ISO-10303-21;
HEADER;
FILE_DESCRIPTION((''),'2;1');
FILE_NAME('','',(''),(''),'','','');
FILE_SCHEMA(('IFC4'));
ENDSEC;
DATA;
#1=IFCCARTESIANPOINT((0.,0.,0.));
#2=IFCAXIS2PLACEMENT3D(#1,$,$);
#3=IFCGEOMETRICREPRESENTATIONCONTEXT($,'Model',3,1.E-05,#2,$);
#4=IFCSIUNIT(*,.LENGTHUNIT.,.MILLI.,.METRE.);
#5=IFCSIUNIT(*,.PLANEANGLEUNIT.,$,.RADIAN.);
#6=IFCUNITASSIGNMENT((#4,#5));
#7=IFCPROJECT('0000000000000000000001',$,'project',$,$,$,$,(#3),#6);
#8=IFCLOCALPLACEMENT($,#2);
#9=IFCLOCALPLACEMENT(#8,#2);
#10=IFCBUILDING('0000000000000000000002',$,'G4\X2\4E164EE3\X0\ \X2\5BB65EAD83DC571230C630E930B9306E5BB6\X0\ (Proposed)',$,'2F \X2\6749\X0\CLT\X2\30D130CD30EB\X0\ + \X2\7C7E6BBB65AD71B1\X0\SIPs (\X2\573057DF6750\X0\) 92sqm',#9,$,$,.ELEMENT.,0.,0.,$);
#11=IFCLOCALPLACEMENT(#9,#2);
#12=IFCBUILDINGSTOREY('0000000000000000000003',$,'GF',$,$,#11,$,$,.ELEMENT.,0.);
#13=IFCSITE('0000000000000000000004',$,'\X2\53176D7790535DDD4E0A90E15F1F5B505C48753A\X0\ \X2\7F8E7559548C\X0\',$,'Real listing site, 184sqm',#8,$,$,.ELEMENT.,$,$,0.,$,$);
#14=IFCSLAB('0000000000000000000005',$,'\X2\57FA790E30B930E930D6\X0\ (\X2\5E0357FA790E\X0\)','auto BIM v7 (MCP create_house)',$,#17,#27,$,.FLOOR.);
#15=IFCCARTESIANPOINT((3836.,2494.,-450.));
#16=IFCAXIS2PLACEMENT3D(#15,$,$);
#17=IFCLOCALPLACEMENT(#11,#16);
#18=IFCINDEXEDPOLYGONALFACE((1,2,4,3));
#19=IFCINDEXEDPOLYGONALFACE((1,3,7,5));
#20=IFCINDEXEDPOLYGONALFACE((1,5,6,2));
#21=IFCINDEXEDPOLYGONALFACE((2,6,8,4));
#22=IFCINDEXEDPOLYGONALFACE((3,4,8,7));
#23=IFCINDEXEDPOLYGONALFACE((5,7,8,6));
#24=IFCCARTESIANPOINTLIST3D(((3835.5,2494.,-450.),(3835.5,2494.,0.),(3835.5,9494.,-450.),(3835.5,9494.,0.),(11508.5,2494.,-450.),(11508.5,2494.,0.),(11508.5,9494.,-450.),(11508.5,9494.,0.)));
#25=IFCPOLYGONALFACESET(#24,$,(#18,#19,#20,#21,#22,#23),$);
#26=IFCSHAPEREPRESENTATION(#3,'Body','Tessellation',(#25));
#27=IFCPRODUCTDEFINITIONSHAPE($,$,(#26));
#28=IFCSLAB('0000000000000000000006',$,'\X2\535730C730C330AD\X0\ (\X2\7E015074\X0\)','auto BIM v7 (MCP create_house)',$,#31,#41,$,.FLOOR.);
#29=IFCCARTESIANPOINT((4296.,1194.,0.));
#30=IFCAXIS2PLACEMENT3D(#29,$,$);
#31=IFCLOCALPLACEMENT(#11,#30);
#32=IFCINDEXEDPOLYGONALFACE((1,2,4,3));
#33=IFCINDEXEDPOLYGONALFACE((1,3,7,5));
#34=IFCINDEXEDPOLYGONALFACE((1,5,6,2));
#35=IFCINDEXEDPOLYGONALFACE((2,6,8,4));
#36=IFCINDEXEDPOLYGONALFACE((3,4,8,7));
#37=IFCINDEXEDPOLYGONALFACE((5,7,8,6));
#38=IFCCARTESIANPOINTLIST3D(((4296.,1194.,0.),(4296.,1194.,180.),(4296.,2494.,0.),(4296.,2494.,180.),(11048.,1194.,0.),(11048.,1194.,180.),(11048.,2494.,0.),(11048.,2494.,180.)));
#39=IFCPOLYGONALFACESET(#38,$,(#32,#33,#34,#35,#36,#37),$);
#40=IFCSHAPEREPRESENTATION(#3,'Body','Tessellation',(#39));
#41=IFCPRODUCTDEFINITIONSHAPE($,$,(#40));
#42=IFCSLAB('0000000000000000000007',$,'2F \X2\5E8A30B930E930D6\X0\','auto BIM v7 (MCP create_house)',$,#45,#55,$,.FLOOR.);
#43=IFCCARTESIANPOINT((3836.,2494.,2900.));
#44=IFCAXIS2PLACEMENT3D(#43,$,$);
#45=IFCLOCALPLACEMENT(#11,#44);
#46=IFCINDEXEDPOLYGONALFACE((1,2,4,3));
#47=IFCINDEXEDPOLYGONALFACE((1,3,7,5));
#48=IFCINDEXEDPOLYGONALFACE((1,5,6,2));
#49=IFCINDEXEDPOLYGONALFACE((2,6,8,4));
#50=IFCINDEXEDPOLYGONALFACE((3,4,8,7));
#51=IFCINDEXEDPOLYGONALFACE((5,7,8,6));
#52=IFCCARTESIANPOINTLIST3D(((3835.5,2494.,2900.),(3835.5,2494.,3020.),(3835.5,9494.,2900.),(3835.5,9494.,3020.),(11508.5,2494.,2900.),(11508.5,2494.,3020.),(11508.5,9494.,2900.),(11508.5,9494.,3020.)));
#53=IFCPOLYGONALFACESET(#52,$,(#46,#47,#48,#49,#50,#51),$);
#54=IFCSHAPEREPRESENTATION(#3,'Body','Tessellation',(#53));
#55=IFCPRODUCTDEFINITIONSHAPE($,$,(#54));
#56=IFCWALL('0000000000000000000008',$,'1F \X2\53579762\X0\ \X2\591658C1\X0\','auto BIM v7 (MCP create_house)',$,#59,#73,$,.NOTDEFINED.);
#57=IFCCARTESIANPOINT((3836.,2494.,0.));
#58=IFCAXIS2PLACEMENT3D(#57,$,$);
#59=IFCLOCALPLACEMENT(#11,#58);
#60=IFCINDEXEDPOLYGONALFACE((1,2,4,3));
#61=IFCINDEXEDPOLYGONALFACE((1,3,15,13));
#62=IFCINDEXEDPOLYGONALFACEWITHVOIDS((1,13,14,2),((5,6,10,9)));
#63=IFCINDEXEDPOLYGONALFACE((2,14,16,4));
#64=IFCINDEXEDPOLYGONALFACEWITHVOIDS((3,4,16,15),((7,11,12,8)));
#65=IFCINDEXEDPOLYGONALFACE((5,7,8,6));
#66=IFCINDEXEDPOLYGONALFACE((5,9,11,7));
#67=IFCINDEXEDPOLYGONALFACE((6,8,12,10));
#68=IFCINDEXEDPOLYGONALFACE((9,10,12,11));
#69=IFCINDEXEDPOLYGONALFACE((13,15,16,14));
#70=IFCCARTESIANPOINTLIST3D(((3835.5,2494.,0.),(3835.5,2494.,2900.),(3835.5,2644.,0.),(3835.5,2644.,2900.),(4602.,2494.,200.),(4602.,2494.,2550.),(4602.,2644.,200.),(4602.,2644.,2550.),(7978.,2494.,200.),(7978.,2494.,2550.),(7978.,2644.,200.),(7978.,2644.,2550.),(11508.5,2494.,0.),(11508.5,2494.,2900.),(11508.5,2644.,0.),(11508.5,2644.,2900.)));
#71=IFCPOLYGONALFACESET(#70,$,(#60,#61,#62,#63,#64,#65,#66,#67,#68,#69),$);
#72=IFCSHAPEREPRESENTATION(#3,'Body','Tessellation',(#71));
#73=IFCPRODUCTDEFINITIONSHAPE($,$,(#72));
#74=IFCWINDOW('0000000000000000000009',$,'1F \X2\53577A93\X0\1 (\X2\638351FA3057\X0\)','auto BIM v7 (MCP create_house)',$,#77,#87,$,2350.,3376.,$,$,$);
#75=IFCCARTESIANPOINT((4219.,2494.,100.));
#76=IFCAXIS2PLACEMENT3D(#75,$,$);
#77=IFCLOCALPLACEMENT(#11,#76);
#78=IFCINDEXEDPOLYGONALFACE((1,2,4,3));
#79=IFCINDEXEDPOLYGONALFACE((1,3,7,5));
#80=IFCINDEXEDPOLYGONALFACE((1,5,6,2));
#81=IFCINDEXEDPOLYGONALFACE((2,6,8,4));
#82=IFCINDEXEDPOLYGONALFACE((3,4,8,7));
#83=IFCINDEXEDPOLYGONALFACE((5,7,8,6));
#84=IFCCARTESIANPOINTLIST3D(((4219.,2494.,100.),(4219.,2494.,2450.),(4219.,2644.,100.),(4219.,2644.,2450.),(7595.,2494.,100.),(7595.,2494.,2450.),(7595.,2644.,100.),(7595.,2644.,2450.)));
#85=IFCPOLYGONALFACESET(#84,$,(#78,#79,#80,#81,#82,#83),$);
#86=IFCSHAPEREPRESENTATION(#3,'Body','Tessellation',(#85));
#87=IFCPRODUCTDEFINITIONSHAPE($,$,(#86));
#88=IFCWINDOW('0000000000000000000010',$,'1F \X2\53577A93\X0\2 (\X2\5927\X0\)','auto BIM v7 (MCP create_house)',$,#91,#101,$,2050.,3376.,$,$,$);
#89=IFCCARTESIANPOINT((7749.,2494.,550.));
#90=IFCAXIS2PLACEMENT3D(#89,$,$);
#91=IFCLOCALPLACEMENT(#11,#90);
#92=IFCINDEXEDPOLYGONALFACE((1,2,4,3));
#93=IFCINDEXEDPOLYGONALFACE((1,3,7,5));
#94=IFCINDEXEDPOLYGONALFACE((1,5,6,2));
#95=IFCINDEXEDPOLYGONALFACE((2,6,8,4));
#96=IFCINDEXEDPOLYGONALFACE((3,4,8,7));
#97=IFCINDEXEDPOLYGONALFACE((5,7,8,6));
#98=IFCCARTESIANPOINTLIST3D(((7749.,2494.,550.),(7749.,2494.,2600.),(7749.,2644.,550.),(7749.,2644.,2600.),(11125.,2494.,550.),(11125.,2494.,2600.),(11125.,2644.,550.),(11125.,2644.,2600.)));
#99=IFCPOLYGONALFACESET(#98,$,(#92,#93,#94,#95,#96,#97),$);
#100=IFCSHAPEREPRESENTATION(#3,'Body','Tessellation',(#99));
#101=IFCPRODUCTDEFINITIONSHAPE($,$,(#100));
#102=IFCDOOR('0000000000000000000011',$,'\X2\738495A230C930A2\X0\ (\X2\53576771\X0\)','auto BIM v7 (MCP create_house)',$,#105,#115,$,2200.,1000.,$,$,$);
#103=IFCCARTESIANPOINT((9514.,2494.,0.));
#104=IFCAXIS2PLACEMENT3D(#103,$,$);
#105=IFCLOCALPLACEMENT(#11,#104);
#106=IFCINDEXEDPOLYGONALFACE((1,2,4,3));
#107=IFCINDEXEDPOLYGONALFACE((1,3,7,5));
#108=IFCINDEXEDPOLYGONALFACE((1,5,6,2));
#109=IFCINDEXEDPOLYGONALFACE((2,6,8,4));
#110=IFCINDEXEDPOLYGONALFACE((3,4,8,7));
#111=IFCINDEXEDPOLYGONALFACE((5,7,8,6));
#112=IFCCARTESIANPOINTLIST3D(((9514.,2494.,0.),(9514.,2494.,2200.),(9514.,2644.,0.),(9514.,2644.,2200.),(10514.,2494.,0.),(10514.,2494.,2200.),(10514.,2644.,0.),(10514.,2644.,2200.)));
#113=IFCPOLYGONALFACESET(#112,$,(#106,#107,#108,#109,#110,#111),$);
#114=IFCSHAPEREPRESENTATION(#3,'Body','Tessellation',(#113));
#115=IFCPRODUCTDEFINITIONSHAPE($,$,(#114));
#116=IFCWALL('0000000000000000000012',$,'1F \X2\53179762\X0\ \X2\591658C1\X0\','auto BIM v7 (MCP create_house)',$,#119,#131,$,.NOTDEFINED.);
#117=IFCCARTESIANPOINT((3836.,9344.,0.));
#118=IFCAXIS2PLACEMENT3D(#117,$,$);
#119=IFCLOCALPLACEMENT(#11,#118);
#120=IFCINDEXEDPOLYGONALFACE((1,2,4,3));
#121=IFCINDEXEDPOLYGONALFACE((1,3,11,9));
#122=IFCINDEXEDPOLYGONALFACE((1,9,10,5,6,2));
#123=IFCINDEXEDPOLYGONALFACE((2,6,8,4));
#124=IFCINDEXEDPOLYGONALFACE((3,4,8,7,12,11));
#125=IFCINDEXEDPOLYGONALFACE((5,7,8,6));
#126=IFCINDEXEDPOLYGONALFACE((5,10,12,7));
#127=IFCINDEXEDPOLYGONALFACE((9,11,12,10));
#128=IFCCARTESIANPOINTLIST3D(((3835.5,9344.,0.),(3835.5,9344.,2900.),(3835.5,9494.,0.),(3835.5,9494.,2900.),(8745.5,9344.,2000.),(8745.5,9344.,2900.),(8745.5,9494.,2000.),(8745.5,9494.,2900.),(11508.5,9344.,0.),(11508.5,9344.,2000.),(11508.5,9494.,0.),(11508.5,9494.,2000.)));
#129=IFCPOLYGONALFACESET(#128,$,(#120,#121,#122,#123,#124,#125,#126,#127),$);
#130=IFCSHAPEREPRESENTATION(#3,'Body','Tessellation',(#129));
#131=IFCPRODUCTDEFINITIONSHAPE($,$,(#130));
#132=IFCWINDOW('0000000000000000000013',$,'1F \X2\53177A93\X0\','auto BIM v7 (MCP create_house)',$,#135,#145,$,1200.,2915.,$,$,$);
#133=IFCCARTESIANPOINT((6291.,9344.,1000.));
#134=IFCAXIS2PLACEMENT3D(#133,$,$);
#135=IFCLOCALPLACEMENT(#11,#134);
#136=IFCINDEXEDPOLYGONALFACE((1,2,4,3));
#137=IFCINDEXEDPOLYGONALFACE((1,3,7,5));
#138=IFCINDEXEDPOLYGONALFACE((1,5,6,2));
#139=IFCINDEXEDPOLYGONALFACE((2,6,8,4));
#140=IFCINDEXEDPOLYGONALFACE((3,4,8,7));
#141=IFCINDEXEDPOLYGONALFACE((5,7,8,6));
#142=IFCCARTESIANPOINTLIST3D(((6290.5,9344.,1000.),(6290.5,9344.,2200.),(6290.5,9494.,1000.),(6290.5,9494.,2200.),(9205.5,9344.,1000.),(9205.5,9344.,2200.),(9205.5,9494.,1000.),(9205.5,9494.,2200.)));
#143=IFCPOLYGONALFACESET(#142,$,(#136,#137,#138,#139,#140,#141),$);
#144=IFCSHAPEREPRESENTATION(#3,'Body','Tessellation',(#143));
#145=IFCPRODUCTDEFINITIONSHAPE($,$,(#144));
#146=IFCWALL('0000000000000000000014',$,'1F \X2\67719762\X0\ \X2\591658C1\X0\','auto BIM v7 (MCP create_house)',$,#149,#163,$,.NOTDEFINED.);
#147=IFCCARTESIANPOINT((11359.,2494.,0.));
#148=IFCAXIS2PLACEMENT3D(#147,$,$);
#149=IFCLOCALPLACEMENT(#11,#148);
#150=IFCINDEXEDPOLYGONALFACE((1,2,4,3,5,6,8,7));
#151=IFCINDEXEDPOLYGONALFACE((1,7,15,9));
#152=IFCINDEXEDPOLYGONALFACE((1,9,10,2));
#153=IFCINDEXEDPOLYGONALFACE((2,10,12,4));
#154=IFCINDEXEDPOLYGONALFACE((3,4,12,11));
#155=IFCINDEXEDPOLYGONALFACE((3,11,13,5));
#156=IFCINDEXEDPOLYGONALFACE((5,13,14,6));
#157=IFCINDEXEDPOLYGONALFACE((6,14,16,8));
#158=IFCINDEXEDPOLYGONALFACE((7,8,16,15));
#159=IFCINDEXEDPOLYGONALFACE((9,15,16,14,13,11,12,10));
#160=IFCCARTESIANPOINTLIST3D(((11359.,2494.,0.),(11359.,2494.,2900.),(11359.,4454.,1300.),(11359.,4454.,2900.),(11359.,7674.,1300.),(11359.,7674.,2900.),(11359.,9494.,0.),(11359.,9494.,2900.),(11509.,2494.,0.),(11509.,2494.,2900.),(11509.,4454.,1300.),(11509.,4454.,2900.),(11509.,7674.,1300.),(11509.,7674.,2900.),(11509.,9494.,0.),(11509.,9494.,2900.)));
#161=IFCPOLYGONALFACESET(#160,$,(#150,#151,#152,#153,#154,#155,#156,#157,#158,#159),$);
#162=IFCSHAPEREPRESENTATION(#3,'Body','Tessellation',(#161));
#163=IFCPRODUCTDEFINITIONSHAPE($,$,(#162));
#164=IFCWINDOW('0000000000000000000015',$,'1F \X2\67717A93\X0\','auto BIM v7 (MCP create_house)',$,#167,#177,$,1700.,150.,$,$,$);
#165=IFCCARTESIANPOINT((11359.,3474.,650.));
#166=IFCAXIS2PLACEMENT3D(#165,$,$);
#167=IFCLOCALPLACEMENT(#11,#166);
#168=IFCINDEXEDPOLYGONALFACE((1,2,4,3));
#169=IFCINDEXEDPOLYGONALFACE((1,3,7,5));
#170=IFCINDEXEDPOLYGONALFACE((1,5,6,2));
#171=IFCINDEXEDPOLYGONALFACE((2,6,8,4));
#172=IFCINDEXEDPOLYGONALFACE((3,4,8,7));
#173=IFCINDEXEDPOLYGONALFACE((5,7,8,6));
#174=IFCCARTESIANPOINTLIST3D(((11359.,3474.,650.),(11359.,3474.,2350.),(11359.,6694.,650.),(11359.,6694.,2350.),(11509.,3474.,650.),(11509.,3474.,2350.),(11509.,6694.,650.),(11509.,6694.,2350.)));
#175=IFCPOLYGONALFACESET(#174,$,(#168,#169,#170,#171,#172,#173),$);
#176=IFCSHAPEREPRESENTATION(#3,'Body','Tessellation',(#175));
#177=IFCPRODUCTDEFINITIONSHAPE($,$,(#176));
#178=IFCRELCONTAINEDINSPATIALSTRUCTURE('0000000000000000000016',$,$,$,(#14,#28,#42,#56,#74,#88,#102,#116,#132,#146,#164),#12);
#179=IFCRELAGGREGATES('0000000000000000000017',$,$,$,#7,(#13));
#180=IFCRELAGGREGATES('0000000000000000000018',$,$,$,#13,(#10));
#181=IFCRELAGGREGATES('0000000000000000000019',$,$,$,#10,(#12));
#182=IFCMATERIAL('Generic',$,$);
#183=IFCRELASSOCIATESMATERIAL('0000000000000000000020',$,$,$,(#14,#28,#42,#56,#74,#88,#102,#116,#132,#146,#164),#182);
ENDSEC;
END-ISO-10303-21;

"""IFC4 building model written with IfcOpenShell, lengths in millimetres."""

from ifc_helpers import new_model, si_unit, frame, frame_2d, origin, place, context, project, spatial, rectangle, extrude, material, element, fill, save


model = new_model("IFC4")

# Units and contexts
model_context = context("Model", 3, precision=1e-05, world=origin())
ifc_project = project(units=[si_unit("LENGTHUNIT", "METRE", prefix="MILLI"), si_unit("PLANEANGLEUNIT", "RADIAN")], contexts=[model_context])

# Site, building, storey
site_placement = place(None, origin())
site = spatial("IfcSite", under=ifc_project, at=site_placement, Name="北海道川上郡弟子屈町 美留和", ObjectType="Real listing site, 184sqm", CompositionType="ELEMENT", RefElevation=0.0)
building_placement = place(site_placement, origin())
building = spatial("IfcBuilding", under=site, at=building_placement, Name="G4世代 家庭菜園テラスの家 (Proposed)", ObjectType="2F 杉CLTパネル + 籾殻断熱SIPs (地域材) 92sqm", CompositionType="ELEMENT", ElevationOfRefHeight=0.0, ElevationOfTerrain=0.0)
storey_placement = place(building_placement, origin())
storey = spatial("IfcBuildingStorey", under=building, at=storey_placement, Name="GF", CompositionType="ELEMENT", Elevation=0.0)

# Slabs
ifc_material = material(Name="Generic")
slab_1_placement = place(storey_placement, frame((3836.0, 2494.0, -450.0)))
element("IfcSlab", 1, at=slab_1_placement, inside=storey, material=ifc_material, Name="基礎スラブ (布基礎)", Description="auto BIM v7 (MCP create_house)", PredefinedType="FLOOR", context=model_context, shape_type="SweptSolid", body=[
    extrude(rectangle(XDim=7673.0, YDim=7000.0, at=frame_2d((3836.0, 3500.0))), frame((3836.0, 2494.0, -450.0)), (0.0, 0.0, 1.0), 450.0),
])
slab_2_placement = place(storey_placement, frame((4296.0, 1194.0, 0.0)))
element("IfcSlab", 2, at=slab_2_placement, inside=storey, material=ifc_material, Name="南デッキ (縁側)", Description="auto BIM v7 (MCP create_house)", PredefinedType="FLOOR", context=model_context, shape_type="SweptSolid", body=[
    extrude(rectangle(XDim=6752.0, YDim=1300.0, at=frame_2d((3376.0, 650.0))), frame((4296.0, 1194.0, 0.0)), (0.0, 0.0, 1.0), 180.0),
])
slab_3_placement = place(storey_placement, frame((3836.0, 2494.0, 2900.0)))
element("IfcSlab", 3, at=slab_3_placement, inside=storey, material=ifc_material, Name="2F 床スラブ", Description="auto BIM v7 (MCP create_house)", PredefinedType="FLOOR", context=model_context, shape_type="SweptSolid", body=[
    extrude(rectangle(XDim=7673.0, YDim=7000.0, at=frame_2d((3836.0, 3500.0))), frame((3836.0, 2494.0, 2900.0)), (0.0, 0.0, 1.0), 120.0),
])

# Wall, openings, windows, door
wall_1_placement = place(storey_placement, frame((3836.0, 2494.0, 0.0)))
wall_1 = element("IfcWall", 4, at=wall_1_placement, inside=storey, material=ifc_material, Name="1F 南面 外壁", Description="auto BIM v7 (MCP create_house)", PredefinedType="NOTDEFINED", context=model_context, shape_type="SweptSolid", body=[
    extrude(rectangle(XDim=7673.0, YDim=150.0, at=frame_2d((3836.0, 75.0))), frame((3836.0, 2494.0, 0.0)), (0.0, 0.0, 1.0), 2900.0),
])
opening_1_placement = place(storey_placement, frame((4219.0, 2494.0, 100.0)))
opening_1 = element("IfcOpeningElement", 5, at=opening_1_placement, cuts=wall_1, PredefinedType="NOTDEFINED", context=model_context, shape_type="SweptSolid", body=[
    extrude(rectangle(XDim=3376.0, YDim=150.0, at=frame_2d((1688.0, 75.0))), frame((4219.0, 2494.0, 100.0)), (0.0, 0.0, 1.0), 2350.0),
])
opening_2_placement = place(storey_placement, frame((7749.0, 2494.0, 550.0)))
opening_2 = element("IfcOpeningElement", 6, at=opening_2_placement, cuts=wall_1, PredefinedType="NOTDEFINED", context=model_context, shape_type="SweptSolid", body=[
    extrude(rectangle(XDim=3376.0, YDim=150.0, at=frame_2d((1688.0, 75.0))), frame((7749.0, 2494.0, 550.0)), (0.0, 0.0, 1.0), 2050.0),
])
opening_3_placement = place(storey_placement, frame((9514.0, 2494.0, 0.0)))
opening_3 = element("IfcOpeningElement", 7, at=opening_3_placement, cuts=wall_1, PredefinedType="NOTDEFINED", context=model_context, shape_type="SweptSolid", body=[
    extrude(rectangle(XDim=1000.0, YDim=150.0, at=frame_2d((500.0, 75.0))), frame((9514.0, 2494.0, 0.0)), (0.0, 0.0, 1.0), 2200.0),
])
window_1_placement = place(storey_placement, frame((4219.0, 2494.0, 100.0)))
window_1 = element("IfcWindow", 8, at=window_1_placement, inside=storey, material=ifc_material, Name="1F 南窓1 (掃出し)", Description="auto BIM v7 (MCP create_house)", OverallHeight=2350.0, OverallWidth=3376.0, context=model_context, shape_type="SweptSolid", body=[
    extrude(rectangle(XDim=3376.0, YDim=150.0, at=frame_2d((1688.0, 75.0))), frame((4219.0, 2494.0, 100.0)), (0.0, 0.0, 1.0), 2350.0),
])
fill(opening_1, window_1)
window_2_placement = place(storey_placement, frame((7749.0, 2494.0, 550.0)))
window_2 = element("IfcWindow", 9, at=window_2_placement, inside=storey, material=ifc_material, Name="1F 南窓2 (大)", Description="auto BIM v7 (MCP create_house)", OverallHeight=2050.0, OverallWidth=3376.0, context=model_context, shape_type="SweptSolid", body=[
    extrude(rectangle(XDim=3376.0, YDim=150.0, at=frame_2d((1688.0, 75.0))), frame((7749.0, 2494.0, 550.0)), (0.0, 0.0, 1.0), 2050.0),
])
fill(opening_2, window_2)
door_placement = place(storey_placement, frame((9514.0, 2494.0, 0.0)))
door = element("IfcDoor", 10, at=door_placement, inside=storey, material=ifc_material, Name="玄関ドア (南東)", Description="auto BIM v7 (MCP create_house)", OverallHeight=2200.0, OverallWidth=1000.0, context=model_context, shape_type="SweptSolid", body=[
    extrude(rectangle(XDim=1000.0, YDim=150.0, at=frame_2d((500.0, 75.0))), frame((9514.0, 2494.0, 0.0)), (0.0, 0.0, 1.0), 2200.0),
])
fill(opening_3, door)

# Walls, openings, windows
wall_2_placement = place(storey_placement, frame((3836.0, 9344.0, 0.0)))
wall_2 = element("IfcWall", 11, at=wall_2_placement, inside=storey, material=ifc_material, Name="1F 北面 外壁", Description="auto BIM v7 (MCP create_house)", PredefinedType="NOTDEFINED", context=model_context, shape_type="SweptSolid", body=[
    extrude(rectangle(XDim=7673.0, YDim=150.0, at=frame_2d((3836.0, 75.0))), frame((3836.0, 9344.0, 0.0)), (0.0, 0.0, 1.0), 2900.0),
])
opening_4_placement = place(storey_placement, frame((6291.0, 9344.0, 1000.0)))
opening_4 = element("IfcOpeningElement", 12, at=opening_4_placement, cuts=wall_2, PredefinedType="NOTDEFINED", context=model_context, shape_type="SweptSolid", body=[
    extrude(rectangle(XDim=2915.0, YDim=150.0, at=frame_2d((1457.0, 75.0))), frame((6291.0, 9344.0, 1000.0)), (0.0, 0.0, 1.0), 1200.0),
])
window_3_placement = place(storey_placement, frame((6291.0, 9344.0, 1000.0)))
window_3 = element("IfcWindow", 13, at=window_3_placement, inside=storey, material=ifc_material, Name="1F 北窓", Description="auto BIM v7 (MCP create_house)", OverallHeight=1200.0, OverallWidth=2915.0, context=model_context, shape_type="SweptSolid", body=[
    extrude(rectangle(XDim=2915.0, YDim=150.0, at=frame_2d((1457.0, 75.0))), frame((6291.0, 9344.0, 1000.0)), (0.0, 0.0, 1.0), 1200.0),
])
fill(opening_4, window_3)
wall_3_placement = place(storey_placement, frame((11359.0, 2494.0, 0.0)))
wall_3 = element("IfcWall", 14, at=wall_3_placement, inside=storey, material=ifc_material, Name="1F 東面 外壁", Description="auto BIM v7 (MCP create_house)", PredefinedType="NOTDEFINED", context=model_context, shape_type="SweptSolid", body=[
    extrude(rectangle(XDim=150.0, YDim=7000.0, at=frame_2d((75.0, 3500.0))), frame((11359.0, 2494.0, 0.0)), (0.0, 0.0, 1.0), 2900.0),
])
opening_5_placement = place(storey_placement, frame((11359.0, 3474.0, 650.0)))
opening_5 = element("IfcOpeningElement", 15, at=opening_5_placement, cuts=wall_3, PredefinedType="NOTDEFINED", context=model_context, shape_type="SweptSolid", body=[
    extrude(rectangle(XDim=150.0, YDim=3220.0, at=frame_2d((75.0, 1610.0))), frame((11359.0, 3474.0, 650.0)), (0.0, 0.0, 1.0), 1700.0),
])
window_4_placement = place(storey_placement, frame((11359.0, 3474.0, 650.0)))
window_4 = element("IfcWindow", 16, at=window_4_placement, inside=storey, material=ifc_material, Name="1F 東窓", Description="auto BIM v7 (MCP create_house)", OverallHeight=1700.0, OverallWidth=150.0, context=model_context, shape_type="SweptSolid", body=[
    extrude(rectangle(XDim=150.0, YDim=3220.0, at=frame_2d((75.0, 1610.0))), frame((11359.0, 3474.0, 650.0)), (0.0, 0.0, 1.0), 1700.0),
])
fill(opening_5, window_4)

save(model, "model.ifc")
